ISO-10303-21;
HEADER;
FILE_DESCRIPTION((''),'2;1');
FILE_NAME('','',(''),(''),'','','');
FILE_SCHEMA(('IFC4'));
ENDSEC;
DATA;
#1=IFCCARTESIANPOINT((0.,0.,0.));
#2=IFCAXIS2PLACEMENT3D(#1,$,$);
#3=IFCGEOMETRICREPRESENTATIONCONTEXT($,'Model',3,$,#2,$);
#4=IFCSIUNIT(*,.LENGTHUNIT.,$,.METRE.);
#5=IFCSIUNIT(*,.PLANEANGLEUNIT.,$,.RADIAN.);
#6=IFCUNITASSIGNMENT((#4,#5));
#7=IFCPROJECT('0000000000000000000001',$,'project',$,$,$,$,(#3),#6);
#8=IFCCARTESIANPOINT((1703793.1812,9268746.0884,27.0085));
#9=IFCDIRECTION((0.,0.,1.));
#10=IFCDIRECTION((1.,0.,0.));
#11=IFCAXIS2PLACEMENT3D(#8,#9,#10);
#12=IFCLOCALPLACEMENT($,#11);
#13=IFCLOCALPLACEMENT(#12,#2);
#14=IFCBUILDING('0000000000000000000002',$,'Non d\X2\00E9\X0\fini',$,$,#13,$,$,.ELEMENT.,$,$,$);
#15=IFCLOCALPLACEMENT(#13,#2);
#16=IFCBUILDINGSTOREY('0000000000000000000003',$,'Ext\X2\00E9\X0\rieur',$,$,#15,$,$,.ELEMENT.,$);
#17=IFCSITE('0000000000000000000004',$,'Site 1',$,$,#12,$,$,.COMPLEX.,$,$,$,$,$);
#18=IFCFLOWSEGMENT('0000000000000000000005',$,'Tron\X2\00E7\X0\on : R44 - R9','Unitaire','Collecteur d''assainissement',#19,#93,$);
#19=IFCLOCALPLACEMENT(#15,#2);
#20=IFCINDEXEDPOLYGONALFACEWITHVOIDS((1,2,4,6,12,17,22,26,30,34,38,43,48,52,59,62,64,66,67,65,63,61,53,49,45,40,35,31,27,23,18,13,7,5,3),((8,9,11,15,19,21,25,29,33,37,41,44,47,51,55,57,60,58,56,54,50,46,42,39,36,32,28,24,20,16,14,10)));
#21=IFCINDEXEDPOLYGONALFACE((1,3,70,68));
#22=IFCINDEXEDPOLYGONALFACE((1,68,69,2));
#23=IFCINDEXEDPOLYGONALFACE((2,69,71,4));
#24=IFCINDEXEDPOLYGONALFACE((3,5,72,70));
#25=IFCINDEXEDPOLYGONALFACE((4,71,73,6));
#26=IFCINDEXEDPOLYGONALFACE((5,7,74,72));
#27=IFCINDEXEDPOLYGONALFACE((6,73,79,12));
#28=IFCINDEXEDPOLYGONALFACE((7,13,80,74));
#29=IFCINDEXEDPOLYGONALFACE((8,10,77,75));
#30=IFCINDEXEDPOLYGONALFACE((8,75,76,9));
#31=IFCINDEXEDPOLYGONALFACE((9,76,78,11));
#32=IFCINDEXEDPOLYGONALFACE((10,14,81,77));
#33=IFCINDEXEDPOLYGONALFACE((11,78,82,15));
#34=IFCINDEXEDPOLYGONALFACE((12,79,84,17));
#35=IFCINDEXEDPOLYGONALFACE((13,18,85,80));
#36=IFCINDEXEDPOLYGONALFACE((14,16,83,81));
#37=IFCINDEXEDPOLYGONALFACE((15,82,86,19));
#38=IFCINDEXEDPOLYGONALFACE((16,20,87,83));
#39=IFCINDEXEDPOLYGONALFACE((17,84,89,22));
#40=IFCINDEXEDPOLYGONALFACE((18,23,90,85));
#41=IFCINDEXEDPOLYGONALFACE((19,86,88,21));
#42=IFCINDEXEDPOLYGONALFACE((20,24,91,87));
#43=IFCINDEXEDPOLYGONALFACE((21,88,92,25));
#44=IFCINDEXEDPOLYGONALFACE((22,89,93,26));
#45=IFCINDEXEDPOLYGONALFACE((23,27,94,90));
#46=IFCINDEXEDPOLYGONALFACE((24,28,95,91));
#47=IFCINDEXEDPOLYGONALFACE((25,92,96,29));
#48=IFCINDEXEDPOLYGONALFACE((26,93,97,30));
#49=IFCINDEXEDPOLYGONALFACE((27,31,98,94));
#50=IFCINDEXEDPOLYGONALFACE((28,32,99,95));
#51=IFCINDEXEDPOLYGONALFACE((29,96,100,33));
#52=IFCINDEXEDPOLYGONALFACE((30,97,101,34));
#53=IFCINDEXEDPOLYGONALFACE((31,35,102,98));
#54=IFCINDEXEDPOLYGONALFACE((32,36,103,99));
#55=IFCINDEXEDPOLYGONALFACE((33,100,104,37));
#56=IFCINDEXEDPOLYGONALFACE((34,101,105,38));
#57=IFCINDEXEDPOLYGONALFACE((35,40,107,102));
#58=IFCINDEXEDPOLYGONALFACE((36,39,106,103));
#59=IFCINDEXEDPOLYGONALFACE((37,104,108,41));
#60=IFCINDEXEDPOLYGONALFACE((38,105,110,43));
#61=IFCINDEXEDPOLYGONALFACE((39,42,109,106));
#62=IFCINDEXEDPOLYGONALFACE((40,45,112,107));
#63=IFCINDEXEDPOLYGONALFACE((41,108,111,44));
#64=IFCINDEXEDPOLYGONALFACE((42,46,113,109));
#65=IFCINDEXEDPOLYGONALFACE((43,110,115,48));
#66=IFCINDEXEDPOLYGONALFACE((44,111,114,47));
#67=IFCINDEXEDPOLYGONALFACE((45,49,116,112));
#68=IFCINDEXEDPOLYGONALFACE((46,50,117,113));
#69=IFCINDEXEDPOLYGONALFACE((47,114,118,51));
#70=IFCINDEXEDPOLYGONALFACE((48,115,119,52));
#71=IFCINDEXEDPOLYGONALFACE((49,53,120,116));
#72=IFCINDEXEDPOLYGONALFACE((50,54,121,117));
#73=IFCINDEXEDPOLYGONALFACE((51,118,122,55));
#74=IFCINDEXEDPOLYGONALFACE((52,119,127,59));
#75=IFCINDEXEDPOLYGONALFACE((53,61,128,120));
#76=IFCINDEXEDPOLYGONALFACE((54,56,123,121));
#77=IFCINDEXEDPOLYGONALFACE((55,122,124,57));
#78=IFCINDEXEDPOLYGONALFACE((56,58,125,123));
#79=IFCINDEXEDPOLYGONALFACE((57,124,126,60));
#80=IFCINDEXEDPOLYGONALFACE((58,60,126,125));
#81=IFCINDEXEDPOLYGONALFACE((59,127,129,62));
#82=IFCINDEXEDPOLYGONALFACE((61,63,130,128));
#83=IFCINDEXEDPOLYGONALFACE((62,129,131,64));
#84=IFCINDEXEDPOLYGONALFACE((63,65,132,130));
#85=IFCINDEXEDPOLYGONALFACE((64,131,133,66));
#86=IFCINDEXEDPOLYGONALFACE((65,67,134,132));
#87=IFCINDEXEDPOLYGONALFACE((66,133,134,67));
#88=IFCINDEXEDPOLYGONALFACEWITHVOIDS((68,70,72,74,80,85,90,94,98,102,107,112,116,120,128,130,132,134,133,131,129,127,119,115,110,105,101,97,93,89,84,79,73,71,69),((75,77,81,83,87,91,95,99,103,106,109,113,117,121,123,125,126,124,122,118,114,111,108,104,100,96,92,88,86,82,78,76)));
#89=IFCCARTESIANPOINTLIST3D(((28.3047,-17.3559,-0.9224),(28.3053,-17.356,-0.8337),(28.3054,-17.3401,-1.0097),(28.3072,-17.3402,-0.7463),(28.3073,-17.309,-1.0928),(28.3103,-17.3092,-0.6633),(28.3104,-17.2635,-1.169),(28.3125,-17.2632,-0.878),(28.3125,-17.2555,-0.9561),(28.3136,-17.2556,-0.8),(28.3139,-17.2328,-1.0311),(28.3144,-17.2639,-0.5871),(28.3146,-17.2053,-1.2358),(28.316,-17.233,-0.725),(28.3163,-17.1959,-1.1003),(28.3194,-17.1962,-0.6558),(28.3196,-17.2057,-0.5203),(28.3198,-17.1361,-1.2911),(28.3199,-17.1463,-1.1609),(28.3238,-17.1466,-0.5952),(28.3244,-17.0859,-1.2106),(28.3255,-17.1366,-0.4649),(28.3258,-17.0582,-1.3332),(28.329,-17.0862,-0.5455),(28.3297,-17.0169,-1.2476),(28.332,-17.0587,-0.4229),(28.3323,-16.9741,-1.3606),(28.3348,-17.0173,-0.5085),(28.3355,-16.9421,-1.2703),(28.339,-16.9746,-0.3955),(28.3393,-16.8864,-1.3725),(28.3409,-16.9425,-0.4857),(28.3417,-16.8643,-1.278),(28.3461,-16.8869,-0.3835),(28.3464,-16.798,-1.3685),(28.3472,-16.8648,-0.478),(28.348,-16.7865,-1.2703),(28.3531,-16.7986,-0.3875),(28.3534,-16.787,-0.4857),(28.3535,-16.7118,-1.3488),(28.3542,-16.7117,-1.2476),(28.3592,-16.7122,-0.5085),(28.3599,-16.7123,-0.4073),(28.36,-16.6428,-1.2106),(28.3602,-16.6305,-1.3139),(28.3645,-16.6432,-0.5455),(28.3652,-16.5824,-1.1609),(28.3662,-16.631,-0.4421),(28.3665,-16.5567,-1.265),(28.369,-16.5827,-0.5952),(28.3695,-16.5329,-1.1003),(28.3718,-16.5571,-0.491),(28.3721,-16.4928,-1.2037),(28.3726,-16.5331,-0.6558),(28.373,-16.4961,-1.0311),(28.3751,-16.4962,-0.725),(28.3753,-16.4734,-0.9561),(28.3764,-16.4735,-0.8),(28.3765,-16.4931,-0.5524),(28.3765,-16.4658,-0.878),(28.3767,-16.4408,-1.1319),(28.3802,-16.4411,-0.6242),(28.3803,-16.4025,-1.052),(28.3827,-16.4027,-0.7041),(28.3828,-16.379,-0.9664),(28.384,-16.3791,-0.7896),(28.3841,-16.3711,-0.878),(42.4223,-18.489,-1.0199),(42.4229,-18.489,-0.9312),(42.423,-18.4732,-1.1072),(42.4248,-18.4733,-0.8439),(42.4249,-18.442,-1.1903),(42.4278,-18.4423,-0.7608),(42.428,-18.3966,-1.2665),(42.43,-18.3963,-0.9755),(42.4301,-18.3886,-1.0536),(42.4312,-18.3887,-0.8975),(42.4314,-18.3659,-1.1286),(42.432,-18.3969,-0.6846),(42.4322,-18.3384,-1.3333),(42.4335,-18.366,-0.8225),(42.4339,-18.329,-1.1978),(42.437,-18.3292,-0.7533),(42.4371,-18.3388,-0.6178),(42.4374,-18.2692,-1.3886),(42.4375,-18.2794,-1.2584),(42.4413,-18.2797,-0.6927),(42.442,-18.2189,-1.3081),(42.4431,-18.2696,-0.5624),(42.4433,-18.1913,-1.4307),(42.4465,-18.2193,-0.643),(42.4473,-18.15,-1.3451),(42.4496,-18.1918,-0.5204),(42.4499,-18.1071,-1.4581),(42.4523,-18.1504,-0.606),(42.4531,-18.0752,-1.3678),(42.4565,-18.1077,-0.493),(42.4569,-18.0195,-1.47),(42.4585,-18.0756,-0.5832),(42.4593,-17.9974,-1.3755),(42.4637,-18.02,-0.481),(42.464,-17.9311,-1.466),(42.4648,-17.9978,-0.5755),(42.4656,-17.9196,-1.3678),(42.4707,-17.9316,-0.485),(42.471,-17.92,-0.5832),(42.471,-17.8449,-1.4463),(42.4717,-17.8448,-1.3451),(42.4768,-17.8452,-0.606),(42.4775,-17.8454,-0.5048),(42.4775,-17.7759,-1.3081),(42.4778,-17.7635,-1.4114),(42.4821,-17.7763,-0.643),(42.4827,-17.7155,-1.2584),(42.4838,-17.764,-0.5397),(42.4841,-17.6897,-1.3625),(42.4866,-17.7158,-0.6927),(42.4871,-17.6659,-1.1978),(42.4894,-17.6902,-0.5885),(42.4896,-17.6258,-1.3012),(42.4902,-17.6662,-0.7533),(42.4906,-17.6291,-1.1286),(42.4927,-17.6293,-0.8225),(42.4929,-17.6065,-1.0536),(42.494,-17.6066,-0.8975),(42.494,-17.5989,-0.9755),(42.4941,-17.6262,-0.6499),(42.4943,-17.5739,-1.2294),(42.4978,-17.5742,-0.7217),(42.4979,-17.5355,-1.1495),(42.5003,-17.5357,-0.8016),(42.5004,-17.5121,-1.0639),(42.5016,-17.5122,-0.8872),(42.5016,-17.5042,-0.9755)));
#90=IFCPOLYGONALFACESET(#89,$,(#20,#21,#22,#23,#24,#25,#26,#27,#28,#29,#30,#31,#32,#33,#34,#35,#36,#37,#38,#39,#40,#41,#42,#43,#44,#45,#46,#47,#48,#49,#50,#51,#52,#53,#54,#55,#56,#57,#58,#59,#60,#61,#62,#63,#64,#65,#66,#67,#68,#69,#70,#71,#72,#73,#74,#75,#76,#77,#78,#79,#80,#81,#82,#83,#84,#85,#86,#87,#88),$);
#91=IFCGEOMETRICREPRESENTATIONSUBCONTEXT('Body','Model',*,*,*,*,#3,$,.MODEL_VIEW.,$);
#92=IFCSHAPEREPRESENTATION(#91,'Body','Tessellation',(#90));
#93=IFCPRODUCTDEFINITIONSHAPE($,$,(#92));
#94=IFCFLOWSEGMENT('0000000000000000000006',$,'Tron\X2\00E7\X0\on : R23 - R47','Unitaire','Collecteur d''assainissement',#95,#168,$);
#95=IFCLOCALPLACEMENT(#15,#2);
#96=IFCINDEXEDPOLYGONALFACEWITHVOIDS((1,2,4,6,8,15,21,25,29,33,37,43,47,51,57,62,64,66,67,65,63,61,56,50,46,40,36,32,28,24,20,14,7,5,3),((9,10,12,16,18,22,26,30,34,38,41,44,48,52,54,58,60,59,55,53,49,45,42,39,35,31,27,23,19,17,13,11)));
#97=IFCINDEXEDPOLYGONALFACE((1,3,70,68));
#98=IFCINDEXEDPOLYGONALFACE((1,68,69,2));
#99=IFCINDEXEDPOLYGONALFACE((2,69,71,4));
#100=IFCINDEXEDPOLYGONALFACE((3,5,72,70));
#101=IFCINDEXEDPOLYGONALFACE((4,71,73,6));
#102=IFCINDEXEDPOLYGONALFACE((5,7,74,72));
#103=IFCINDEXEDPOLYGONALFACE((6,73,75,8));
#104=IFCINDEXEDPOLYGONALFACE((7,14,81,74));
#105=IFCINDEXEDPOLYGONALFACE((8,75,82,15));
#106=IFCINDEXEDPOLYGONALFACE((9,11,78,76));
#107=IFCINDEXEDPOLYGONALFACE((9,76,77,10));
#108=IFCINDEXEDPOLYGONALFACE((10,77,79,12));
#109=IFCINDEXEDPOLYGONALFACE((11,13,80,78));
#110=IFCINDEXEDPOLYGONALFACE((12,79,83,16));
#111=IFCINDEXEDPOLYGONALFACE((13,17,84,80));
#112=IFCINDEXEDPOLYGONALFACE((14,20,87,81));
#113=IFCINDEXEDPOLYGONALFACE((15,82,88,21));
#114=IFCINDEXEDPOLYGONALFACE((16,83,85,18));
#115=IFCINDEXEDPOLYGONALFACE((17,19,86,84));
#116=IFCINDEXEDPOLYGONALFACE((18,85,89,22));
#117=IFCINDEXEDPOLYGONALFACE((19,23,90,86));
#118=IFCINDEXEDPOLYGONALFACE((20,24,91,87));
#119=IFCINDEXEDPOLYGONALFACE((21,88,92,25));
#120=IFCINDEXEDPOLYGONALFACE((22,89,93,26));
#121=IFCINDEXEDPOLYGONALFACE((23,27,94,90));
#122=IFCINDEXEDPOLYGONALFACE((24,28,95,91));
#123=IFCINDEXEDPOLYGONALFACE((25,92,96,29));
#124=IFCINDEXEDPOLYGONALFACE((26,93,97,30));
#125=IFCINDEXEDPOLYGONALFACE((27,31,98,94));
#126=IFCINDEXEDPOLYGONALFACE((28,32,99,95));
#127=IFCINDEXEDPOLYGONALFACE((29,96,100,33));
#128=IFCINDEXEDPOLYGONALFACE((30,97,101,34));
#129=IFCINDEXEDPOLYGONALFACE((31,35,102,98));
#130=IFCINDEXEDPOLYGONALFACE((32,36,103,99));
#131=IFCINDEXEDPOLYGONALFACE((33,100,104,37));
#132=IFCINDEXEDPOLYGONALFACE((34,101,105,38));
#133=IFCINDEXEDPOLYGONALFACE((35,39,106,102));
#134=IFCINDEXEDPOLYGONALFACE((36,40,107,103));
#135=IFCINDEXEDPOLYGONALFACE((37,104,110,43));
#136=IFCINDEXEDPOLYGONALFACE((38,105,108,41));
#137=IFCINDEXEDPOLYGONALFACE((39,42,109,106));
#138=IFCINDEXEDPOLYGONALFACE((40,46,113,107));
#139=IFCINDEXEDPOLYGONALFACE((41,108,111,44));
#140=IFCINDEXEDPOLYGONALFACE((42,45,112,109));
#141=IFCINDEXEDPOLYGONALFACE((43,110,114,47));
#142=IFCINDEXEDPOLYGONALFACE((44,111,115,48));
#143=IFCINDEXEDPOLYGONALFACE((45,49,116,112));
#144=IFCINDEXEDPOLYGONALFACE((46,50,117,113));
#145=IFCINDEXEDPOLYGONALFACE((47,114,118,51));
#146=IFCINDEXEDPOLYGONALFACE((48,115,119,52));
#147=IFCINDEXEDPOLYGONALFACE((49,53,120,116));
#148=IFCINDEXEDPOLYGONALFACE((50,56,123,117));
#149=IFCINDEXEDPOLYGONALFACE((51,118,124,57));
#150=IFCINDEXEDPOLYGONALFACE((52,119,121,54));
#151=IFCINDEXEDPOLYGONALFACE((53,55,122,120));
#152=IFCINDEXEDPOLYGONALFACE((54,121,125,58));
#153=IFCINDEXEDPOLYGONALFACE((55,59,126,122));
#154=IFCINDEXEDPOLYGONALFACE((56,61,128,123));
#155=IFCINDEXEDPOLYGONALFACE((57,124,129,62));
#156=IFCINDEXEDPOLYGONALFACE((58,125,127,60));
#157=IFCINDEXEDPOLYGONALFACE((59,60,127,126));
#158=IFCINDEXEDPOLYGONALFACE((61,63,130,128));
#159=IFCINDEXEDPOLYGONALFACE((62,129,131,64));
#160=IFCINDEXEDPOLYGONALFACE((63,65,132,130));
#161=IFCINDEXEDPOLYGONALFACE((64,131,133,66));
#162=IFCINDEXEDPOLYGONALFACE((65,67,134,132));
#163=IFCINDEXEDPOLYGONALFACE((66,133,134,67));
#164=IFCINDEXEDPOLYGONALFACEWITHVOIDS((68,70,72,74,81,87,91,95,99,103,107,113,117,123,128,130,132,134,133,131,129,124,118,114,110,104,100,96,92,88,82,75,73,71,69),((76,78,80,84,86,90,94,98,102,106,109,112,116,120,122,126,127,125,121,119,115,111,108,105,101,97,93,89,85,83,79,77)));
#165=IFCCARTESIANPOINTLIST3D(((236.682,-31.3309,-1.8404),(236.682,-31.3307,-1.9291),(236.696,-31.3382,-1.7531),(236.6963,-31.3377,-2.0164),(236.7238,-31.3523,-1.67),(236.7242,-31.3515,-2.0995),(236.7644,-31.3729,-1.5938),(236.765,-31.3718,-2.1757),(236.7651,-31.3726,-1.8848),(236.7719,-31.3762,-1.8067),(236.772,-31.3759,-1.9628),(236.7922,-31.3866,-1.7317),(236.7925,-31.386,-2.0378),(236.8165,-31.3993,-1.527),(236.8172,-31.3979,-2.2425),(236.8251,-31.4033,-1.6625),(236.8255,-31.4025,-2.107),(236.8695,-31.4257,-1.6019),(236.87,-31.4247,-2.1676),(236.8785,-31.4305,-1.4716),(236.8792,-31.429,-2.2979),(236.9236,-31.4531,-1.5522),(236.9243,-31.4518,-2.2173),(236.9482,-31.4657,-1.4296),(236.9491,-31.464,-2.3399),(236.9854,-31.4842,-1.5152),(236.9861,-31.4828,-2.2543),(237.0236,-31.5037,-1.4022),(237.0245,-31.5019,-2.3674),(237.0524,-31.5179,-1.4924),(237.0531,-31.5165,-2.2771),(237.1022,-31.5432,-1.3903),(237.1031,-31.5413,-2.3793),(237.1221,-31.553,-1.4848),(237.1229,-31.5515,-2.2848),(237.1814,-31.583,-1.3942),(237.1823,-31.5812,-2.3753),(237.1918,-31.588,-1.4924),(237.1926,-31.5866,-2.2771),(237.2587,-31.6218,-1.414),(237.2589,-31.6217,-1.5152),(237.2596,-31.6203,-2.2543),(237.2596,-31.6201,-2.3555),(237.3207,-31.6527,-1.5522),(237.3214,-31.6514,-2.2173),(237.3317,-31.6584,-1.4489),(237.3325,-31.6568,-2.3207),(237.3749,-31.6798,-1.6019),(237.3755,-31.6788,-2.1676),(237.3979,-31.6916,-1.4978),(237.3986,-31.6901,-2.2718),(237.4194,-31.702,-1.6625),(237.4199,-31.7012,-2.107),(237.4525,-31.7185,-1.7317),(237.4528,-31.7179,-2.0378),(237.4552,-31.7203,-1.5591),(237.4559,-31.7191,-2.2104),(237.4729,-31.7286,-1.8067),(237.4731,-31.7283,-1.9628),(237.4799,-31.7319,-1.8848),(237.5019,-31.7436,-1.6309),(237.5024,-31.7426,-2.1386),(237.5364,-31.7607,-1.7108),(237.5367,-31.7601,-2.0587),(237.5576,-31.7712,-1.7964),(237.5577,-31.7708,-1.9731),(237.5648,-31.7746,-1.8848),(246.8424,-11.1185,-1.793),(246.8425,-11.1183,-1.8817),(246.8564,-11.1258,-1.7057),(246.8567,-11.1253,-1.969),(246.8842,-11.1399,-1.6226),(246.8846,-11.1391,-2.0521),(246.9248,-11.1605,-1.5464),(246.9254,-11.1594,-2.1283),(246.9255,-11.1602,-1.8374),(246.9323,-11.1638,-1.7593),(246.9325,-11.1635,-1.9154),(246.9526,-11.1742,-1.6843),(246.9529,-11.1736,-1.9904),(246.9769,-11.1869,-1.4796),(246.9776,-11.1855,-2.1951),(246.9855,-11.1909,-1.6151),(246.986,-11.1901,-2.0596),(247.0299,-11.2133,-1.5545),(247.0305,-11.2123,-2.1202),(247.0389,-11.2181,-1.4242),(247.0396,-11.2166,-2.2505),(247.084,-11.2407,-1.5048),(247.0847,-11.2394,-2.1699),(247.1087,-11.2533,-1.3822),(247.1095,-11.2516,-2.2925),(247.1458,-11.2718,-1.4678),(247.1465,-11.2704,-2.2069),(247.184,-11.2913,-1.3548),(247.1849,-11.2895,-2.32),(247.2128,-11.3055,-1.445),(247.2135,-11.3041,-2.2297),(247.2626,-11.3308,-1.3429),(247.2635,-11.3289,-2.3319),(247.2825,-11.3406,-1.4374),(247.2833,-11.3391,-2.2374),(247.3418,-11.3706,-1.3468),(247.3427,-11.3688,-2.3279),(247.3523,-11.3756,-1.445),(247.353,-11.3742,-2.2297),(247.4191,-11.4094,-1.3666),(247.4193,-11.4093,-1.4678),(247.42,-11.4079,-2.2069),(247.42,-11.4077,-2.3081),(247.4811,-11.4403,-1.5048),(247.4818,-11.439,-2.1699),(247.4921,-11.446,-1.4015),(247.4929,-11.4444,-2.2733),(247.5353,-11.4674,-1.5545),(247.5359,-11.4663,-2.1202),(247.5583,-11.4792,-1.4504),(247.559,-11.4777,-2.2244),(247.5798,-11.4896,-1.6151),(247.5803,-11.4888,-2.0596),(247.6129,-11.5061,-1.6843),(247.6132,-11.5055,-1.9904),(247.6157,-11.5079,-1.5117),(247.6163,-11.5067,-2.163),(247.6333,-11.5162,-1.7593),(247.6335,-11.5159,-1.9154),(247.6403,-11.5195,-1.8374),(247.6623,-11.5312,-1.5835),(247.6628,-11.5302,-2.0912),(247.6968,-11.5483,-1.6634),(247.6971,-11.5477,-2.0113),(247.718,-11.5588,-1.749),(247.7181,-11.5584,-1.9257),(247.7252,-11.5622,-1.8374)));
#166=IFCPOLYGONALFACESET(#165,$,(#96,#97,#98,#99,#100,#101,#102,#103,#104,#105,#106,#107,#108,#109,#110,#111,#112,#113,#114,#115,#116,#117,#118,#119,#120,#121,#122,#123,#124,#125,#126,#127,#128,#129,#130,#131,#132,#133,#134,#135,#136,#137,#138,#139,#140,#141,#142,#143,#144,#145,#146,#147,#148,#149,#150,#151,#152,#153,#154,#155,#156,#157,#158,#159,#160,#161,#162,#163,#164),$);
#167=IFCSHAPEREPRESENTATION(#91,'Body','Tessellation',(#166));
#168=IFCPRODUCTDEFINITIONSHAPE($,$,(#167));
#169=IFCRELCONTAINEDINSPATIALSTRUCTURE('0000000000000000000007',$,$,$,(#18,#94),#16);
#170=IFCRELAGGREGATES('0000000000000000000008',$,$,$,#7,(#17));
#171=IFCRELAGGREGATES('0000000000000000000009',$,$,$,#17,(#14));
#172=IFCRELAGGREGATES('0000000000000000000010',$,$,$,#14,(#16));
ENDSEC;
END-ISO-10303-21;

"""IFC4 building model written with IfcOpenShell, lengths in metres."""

from ifc_helpers import new_model, si_unit, frame, origin, origin_2d, place, context, subcontext, project, spatial, hollow_circle, extrude, element, save


model = new_model("IFC4")

# Units and contexts
model_context = context("Model", 3, world=origin())
body_context = subcontext(model_context, "Body", "Model", "MODEL_VIEW")
ifc_project = project(units=[si_unit("LENGTHUNIT", "METRE"), si_unit("PLANEANGLEUNIT", "RADIAN")], contexts=[model_context])

# Site, building, storey
site_placement = place(None, frame((1703793.1812, 9268746.0884, 27.0085), z_axis=(0.0, 0.0, 1.0), x_axis=(1.0, 0.0, 0.0)))
site = spatial("IfcSite", under=ifc_project, at=site_placement, Name="Site 1", CompositionType="COMPLEX")
building_placement = place(site_placement, origin())
building = spatial("IfcBuilding", under=site, at=building_placement, Name="Non défini", CompositionType="ELEMENT")
storey_placement = place(building_placement, origin())
storey = spatial("IfcBuildingStorey", under=building, at=storey_placement, Name="Extérieur", CompositionType="ELEMENT")

# Flow segments
flow_segment_1_placement = place(storey_placement, origin())
element("IfcFlowSegment", 1, at=flow_segment_1_placement, inside=storey, Name="Tronçon : R44 - R9", Description="Unitaire", ObjectType="Collecteur d'assainissement", context=body_context, shape_type="SweptSolid", body=[
    extrude(hollow_circle(Radius=0.495, WallThickness=0.095, at=origin_2d()), frame((28.3445, -16.8645, -0.878), z_axis=(0.996771, -0.08, -0.006885), x_axis=(0.080002, 0.996795, 0.0)), (0.0, 0.0, 1.0), 14.1633),
])
flow_segment_2_placement = place(storey_placement, origin())
element("IfcFlowSegment", 2, at=flow_segment_2_placement, inside=storey, Name="Tronçon : R23 - R47", Description="Unitaire", ObjectType="Collecteur d'assainissement", context=body_context, shape_type="SweptSolid", body=[
    extrude(hollow_circle(Radius=0.495, WallThickness=0.095, at=origin_2d()), frame((247.2829, -11.3398, -1.8374), z_axis=(-0.449128, -0.893465, -0.002095), x_axis=(0.893467, -0.449129, 0.0)), (0.0, 0.0, 1.0), 22.6225),
])

save(model, "model.ifc")
